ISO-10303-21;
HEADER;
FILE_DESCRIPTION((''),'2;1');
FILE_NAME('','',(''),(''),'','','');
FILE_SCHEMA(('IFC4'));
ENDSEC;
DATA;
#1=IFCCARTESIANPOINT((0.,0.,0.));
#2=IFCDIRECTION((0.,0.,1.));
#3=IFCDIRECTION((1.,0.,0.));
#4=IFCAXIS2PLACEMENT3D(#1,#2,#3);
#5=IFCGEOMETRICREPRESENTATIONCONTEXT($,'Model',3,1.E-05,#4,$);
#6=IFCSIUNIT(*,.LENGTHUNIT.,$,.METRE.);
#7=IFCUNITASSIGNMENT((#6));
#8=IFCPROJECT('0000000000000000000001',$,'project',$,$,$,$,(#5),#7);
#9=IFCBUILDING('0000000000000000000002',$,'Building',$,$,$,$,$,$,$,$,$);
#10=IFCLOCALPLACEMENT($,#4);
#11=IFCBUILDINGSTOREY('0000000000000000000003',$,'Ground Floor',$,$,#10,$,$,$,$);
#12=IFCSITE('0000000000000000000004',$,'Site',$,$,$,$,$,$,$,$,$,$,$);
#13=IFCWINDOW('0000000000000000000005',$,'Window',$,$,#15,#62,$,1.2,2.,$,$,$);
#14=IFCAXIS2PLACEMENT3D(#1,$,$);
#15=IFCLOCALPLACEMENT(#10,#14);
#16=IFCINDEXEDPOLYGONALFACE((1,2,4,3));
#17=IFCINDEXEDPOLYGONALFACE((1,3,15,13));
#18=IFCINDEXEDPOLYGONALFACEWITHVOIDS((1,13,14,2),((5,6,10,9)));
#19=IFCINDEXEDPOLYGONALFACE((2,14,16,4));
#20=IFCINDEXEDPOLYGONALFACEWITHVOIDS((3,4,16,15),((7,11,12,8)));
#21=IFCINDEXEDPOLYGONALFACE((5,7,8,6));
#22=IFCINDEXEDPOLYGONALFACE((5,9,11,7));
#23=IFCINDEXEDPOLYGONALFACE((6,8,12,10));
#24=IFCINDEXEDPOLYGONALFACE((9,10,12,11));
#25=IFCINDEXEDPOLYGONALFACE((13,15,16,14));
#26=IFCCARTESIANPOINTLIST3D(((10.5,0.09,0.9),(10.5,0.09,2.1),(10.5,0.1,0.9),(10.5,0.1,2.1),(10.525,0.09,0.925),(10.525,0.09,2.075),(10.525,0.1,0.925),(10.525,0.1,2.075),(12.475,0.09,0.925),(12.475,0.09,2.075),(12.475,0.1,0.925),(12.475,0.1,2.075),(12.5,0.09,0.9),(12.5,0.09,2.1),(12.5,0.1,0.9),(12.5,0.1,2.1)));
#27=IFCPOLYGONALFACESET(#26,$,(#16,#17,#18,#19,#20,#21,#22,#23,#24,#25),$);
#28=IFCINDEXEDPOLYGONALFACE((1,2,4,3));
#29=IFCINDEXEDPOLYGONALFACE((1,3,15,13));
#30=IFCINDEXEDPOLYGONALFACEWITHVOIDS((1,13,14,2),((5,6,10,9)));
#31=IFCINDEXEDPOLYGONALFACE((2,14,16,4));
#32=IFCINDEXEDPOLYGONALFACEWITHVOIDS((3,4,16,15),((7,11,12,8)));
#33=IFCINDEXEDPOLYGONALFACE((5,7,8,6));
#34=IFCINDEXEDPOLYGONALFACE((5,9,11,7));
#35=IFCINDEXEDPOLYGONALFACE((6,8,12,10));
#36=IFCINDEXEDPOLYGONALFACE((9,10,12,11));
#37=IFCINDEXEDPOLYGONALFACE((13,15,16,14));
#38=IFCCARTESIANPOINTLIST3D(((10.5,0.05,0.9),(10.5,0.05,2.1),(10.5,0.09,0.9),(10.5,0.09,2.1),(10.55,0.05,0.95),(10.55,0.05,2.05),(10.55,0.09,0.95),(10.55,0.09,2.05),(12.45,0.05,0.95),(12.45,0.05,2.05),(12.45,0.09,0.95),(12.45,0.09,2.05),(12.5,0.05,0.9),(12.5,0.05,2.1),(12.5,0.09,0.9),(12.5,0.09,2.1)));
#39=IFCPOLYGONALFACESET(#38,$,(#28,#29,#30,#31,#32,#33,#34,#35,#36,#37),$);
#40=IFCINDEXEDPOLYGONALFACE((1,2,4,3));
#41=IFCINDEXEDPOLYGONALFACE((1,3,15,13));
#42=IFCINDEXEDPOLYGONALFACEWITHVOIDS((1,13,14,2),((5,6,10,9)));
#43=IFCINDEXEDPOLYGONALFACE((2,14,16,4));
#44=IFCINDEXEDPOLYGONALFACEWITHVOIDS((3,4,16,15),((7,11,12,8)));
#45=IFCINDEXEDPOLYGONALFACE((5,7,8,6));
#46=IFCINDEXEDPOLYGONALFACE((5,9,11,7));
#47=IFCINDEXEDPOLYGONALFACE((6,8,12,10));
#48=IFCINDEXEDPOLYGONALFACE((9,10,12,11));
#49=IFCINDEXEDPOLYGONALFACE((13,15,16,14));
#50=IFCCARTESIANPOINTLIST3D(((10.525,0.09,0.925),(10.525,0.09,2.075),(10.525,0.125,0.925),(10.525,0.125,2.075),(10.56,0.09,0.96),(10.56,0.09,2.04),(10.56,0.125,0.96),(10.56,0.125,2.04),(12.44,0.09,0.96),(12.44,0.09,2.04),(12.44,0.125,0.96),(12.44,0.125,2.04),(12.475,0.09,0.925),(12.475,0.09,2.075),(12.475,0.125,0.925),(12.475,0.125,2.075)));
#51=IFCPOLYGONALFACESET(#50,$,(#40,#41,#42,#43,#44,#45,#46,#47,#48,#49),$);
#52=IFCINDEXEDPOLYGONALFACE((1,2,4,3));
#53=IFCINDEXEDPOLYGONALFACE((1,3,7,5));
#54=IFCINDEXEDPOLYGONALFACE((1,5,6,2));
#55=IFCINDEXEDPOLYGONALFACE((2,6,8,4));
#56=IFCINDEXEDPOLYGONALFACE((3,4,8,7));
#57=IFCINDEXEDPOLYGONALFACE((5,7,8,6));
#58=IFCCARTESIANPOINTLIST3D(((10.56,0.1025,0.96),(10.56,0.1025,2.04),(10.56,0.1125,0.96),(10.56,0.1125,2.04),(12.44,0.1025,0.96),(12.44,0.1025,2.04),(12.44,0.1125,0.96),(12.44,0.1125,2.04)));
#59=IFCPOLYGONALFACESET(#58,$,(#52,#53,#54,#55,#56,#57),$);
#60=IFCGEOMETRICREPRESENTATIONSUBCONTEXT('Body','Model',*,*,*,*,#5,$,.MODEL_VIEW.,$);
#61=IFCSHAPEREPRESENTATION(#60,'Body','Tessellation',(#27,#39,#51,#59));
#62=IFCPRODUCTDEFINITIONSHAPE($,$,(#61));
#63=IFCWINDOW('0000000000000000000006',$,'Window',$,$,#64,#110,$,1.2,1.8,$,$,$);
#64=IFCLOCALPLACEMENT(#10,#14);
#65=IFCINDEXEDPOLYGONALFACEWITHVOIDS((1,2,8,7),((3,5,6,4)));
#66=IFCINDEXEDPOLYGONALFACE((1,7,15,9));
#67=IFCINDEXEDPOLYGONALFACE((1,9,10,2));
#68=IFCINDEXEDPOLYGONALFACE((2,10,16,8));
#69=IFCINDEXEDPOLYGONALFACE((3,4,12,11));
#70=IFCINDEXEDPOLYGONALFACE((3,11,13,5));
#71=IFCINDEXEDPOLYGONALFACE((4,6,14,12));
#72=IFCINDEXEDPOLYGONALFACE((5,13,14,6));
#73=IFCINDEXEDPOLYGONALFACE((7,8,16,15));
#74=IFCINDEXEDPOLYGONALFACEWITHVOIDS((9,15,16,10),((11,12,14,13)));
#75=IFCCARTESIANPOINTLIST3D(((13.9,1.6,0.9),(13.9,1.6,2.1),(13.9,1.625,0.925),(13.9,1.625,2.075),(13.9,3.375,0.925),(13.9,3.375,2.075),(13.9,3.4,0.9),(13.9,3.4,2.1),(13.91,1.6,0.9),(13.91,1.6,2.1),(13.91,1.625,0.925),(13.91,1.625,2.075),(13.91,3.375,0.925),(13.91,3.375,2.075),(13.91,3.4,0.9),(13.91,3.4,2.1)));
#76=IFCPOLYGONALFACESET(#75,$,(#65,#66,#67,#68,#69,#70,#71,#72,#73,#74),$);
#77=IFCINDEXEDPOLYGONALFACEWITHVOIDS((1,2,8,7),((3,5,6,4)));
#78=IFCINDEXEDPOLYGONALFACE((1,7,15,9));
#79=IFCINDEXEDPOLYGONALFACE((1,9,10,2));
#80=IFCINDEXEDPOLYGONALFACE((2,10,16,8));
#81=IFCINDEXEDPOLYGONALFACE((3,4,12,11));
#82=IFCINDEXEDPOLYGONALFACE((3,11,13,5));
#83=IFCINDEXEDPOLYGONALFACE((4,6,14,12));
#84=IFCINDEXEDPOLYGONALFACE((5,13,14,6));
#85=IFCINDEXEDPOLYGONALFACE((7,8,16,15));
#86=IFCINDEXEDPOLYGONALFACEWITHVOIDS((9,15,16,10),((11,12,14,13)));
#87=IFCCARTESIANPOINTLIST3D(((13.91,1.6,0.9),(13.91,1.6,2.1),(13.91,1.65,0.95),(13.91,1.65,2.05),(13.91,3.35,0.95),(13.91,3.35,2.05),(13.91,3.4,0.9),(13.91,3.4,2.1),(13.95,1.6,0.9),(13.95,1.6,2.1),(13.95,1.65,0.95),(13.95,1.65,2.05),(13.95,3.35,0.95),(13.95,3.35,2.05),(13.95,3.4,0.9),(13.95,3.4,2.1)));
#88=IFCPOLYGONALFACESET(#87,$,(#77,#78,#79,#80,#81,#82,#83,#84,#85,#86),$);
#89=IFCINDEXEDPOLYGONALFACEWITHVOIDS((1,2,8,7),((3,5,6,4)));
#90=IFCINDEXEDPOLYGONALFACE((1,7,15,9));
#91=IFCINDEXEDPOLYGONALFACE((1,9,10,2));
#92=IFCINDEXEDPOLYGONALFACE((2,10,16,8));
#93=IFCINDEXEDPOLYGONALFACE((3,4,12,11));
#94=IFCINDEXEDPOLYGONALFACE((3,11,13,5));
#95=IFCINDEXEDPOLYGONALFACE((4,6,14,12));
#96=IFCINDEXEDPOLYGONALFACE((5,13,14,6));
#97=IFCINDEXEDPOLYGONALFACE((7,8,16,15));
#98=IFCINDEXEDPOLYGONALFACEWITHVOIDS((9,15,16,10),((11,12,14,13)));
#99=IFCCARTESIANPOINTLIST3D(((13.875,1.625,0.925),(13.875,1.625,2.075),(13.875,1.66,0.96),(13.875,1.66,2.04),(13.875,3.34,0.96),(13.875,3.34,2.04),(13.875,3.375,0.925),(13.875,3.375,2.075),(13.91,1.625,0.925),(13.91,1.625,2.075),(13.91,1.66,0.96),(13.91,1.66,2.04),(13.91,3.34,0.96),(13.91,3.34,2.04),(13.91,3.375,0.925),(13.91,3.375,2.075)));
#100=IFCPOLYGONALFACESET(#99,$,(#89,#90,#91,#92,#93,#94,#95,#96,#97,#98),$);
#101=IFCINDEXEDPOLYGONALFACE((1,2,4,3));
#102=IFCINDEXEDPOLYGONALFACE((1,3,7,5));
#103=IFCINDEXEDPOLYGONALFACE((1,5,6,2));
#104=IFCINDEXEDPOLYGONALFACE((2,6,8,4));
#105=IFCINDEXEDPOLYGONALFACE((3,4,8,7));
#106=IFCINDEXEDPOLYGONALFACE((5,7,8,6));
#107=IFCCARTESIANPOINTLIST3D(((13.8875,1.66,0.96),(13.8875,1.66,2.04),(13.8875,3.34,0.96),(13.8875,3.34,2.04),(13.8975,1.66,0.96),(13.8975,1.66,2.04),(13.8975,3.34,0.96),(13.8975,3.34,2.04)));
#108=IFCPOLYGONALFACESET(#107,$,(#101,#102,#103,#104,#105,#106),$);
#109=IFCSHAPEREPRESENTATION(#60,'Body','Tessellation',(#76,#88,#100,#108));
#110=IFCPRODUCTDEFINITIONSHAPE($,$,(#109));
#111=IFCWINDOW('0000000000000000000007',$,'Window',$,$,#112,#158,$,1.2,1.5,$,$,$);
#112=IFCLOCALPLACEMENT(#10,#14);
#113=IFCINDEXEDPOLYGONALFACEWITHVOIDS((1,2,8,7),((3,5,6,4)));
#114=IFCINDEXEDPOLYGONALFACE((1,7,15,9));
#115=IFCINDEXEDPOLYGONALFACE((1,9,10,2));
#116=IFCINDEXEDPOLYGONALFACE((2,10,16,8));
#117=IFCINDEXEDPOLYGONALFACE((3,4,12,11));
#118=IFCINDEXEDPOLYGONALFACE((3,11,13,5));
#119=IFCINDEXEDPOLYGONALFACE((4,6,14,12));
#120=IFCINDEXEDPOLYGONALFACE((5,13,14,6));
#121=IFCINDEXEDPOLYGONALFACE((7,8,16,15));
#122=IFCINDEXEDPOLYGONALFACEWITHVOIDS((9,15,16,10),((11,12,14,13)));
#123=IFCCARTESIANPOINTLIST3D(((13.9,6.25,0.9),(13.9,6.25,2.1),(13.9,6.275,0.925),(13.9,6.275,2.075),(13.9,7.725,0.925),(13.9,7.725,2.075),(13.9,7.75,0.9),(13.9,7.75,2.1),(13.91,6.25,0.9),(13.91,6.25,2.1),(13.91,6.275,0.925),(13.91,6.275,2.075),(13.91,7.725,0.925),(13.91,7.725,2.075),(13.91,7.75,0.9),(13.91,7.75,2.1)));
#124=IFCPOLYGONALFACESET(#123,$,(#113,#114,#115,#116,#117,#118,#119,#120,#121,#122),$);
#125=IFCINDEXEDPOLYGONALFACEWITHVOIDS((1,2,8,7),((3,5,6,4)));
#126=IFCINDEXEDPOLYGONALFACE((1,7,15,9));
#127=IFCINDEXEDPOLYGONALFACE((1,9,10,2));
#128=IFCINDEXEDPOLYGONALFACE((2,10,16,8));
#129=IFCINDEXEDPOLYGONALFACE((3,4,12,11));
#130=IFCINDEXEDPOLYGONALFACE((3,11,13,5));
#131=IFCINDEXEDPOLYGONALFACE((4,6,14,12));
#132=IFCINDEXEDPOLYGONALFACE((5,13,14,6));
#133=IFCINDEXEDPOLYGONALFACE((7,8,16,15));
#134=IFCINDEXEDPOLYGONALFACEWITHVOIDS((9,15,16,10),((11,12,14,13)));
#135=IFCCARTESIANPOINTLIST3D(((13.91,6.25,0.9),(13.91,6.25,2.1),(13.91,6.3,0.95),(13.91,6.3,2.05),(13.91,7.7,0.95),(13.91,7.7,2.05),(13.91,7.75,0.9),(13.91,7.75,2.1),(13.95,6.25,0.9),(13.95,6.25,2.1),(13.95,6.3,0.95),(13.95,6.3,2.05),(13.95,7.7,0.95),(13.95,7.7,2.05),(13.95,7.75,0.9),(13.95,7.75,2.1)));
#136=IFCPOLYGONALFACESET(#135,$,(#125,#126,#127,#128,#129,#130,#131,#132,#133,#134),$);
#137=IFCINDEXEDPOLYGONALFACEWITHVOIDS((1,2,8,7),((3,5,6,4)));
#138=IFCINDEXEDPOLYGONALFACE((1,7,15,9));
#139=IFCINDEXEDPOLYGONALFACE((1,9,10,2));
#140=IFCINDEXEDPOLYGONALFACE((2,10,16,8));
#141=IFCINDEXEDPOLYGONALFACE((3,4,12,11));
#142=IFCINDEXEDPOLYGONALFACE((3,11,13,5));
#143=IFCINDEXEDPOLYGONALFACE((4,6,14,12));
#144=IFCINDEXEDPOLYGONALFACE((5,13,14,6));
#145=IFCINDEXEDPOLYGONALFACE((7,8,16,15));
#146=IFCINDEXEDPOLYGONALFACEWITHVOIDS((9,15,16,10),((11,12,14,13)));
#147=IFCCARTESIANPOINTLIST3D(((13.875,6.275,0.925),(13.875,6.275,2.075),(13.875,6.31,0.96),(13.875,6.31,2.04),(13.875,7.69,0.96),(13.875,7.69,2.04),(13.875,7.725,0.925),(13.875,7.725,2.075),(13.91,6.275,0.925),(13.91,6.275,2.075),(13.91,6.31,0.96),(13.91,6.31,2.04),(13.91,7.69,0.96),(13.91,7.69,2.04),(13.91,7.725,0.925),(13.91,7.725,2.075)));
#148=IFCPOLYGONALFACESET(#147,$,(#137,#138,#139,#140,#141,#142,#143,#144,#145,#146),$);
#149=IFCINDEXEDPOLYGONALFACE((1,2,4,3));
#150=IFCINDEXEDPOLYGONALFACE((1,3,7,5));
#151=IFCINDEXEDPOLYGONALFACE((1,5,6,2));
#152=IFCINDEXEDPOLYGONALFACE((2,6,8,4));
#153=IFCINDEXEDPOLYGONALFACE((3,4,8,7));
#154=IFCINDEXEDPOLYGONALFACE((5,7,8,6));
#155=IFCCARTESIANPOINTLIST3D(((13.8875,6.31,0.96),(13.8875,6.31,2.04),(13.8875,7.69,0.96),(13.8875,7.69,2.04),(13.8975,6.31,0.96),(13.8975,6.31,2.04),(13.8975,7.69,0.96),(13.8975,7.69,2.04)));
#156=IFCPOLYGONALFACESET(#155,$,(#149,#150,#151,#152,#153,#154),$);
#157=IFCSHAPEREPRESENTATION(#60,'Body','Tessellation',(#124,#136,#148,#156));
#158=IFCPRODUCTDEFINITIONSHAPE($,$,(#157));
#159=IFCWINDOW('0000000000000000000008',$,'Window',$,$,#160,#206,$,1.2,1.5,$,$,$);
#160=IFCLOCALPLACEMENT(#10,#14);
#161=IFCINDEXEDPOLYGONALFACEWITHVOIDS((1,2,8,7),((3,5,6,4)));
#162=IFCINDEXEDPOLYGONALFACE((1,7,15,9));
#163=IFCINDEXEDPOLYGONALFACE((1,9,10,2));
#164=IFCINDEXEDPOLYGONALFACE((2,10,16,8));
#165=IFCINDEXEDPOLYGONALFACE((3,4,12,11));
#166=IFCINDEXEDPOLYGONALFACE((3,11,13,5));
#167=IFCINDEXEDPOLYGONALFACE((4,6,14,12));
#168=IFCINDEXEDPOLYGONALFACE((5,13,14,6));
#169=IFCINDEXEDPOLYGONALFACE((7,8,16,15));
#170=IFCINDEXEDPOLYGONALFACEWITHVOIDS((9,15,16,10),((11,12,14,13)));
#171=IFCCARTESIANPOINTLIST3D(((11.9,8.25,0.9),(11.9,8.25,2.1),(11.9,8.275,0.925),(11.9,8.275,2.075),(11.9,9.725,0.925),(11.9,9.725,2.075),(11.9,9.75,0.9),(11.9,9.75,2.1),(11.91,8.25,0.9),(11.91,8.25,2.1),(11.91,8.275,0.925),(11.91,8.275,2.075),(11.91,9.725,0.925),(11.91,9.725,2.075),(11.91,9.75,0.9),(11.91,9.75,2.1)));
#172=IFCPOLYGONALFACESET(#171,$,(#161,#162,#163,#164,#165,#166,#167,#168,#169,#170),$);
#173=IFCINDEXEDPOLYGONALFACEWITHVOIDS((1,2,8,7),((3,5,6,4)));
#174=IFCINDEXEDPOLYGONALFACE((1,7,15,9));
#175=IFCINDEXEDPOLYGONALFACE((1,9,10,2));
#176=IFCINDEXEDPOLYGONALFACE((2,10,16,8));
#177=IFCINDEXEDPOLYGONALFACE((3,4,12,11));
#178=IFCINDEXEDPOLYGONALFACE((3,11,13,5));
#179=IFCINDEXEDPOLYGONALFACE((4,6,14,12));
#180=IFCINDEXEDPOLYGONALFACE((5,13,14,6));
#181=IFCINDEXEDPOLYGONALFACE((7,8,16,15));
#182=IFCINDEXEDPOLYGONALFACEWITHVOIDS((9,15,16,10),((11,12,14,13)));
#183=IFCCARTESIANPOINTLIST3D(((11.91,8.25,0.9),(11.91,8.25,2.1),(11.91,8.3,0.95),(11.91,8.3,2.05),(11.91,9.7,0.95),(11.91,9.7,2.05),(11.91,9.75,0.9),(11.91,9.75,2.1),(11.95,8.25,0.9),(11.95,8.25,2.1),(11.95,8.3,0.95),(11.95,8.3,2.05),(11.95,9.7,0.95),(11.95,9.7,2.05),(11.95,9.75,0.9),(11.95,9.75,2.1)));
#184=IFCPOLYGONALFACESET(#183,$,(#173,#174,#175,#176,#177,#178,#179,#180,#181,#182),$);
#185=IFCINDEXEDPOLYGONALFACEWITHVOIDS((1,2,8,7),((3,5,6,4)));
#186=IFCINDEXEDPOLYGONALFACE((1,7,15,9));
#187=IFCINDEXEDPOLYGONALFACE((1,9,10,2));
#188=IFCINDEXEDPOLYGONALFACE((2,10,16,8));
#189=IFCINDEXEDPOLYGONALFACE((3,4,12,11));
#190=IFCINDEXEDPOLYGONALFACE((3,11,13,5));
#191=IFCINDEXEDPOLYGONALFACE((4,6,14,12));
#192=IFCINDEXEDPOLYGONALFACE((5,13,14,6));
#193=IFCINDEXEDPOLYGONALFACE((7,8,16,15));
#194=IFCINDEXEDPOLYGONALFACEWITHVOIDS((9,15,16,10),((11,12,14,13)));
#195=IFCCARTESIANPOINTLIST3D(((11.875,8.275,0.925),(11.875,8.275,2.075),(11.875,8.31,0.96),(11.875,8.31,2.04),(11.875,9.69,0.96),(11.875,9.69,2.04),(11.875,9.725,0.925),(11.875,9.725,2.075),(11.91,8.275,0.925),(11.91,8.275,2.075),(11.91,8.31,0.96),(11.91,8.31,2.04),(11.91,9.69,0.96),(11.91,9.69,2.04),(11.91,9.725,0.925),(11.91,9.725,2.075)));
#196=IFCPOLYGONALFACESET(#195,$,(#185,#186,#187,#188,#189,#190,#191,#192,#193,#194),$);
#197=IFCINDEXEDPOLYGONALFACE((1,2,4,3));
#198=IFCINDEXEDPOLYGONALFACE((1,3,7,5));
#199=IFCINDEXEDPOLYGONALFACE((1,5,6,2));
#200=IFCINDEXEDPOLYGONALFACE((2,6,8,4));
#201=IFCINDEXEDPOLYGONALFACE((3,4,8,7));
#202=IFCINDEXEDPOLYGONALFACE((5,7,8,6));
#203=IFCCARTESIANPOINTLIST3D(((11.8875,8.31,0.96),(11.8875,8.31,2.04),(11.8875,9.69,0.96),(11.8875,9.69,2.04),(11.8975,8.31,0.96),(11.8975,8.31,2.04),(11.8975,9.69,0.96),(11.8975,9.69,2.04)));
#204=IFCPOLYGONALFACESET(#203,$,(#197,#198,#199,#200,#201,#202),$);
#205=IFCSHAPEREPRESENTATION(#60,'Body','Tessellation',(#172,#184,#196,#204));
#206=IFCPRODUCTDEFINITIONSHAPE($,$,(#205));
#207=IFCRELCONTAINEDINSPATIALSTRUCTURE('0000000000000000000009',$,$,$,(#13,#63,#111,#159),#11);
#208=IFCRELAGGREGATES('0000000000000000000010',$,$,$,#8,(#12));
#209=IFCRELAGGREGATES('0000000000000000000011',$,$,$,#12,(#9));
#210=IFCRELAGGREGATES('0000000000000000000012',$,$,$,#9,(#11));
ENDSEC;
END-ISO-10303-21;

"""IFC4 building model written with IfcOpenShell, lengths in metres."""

from ifc_helpers import new_model, si_unit, frame, origin_with_axes, place, context, subcontext, project, spatial, line, indexed_curve, outline, extrude, element, save


model = new_model("IFC4")

# Units and contexts
model_context = context("Model", 3, precision=1e-05, world=origin_with_axes())
body_context = subcontext(model_context, "Body", "Model", "MODEL_VIEW")
ifc_project = project(units=[si_unit("LENGTHUNIT", "METRE")], contexts=[model_context])

# Site, building, storey
site = spatial("IfcSite", under=ifc_project, Name="Site")
building = spatial("IfcBuilding", under=site, Name="Building")
storey_placement = place(None, origin_with_axes())
storey = spatial("IfcBuildingStorey", under=building, at=storey_placement, Name="Ground Floor")

# Windows
window_1_placement = place(storey_placement, frame((10.5, 0.0, 0.9), z_axis=(0.0, 0.0, 1.0), x_axis=(1.0, 0.0, 0.0)))
element("IfcWindow", 1, at=window_1_placement, inside=storey, Name="Window", OverallHeight=1.2, OverallWidth=2.0, context=body_context, shape_type="SweptSolid", body=[
    extrude(outline(indexed_curve([(0.0, 0.0), (2.0, 0.0), (2.0, 1.2), (0.0, 1.2)], segments=[line(1, 2, 3, 4, 1)]), holes=[indexed_curve([(0.025, 0.025), (1.975, 0.025), (1.975, 1.175), (0.025, 1.175)], segments=[line(1, 2, 3, 4, 1)])]), frame((0.0, 0.09, 0.0), z_axis=(0.0, -1.0, 0.0), x_axis=(1.0, 0.0, 0.0)), (0.0, 0.0, -1.0), 0.01),
    extrude(outline(indexed_curve([(0.0, 0.0), (2.0, 0.0), (2.0, 1.2), (0.0, 1.2)], segments=[line(1, 2, 3, 4, 1)]), holes=[indexed_curve([(0.05, 0.05), (1.95, 0.05), (1.95, 1.15), (0.05, 1.15)], segments=[line(1, 2, 3, 4, 1)])]), frame((0.0, 0.05, 0.0), z_axis=(0.0, -1.0, 0.0), x_axis=(1.0, 0.0, 0.0)), (0.0, 0.0, -1.0), 0.04),
    extrude(outline(indexed_curve([(0.0, 0.0), (1.95, 0.0), (1.95, 1.15), (0.0, 1.15)], segments=[line(1, 2, 3, 4, 1)]), holes=[indexed_curve([(0.035, 0.035), (1.915, 0.035), (1.915, 1.115), (0.035, 1.115)], segments=[line(1, 2, 3, 4, 1)])]), frame((0.025, 0.09, 0.025), z_axis=(0.0, -1.0, 0.0), x_axis=(1.0, 0.0, 0.0)), (0.0, 0.0, -1.0), 0.035),
    extrude(outline(indexed_curve([(0.035, 0.035), (1.915, 0.035), (1.915, 1.115), (0.035, 1.115)], segments=[line(1, 2, 3, 4, 1)])), frame((0.025, 0.1025, 0.025), z_axis=(0.0, -1.0, 0.0), x_axis=(1.0, 0.0, 0.0)), (0.0, 0.0, -1.0), 0.01),
])
window_2_placement = place(storey_placement, frame((14.0, 1.6, 0.9), z_axis=(0.0, 0.0, 1.0), x_axis=(0.0, 1.0, 0.0)))
element("IfcWindow", 2, at=window_2_placement, inside=storey, Name="Window", OverallHeight=1.2, OverallWidth=1.8, context=body_context, shape_type="SweptSolid", body=[
    extrude(outline(indexed_curve([(0.0, 0.0), (1.8, 0.0), (1.8, 1.2), (0.0, 1.2)], segments=[line(1, 2, 3, 4, 1)]), holes=[indexed_curve([(0.025, 0.025), (1.775, 0.025), (1.775, 1.175), (0.025, 1.175)], segments=[line(1, 2, 3, 4, 1)])]), frame((0.0, 0.09, 0.0), z_axis=(0.0, -1.0, 0.0), x_axis=(1.0, 0.0, 0.0)), (0.0, 0.0, -1.0), 0.01),
    extrude(outline(indexed_curve([(0.0, 0.0), (1.8, 0.0), (1.8, 1.2), (0.0, 1.2)], segments=[line(1, 2, 3, 4, 1)]), holes=[indexed_curve([(0.05, 0.05), (1.75, 0.05), (1.75, 1.15), (0.05, 1.15)], segments=[line(1, 2, 3, 4, 1)])]), frame((0.0, 0.05, 0.0), z_axis=(0.0, -1.0, 0.0), x_axis=(1.0, 0.0, 0.0)), (0.0, 0.0, -1.0), 0.04),
    extrude(outline(indexed_curve([(0.0, 0.0), (1.75, 0.0), (1.75, 1.15), (0.0, 1.15)], segments=[line(1, 2, 3, 4, 1)]), holes=[indexed_curve([(0.035, 0.035), (1.715, 0.035), (1.715, 1.115), (0.035, 1.115)], segments=[line(1, 2, 3, 4, 1)])]), frame((0.025, 0.09, 0.025), z_axis=(0.0, -1.0, 0.0), x_axis=(1.0, 0.0, 0.0)), (0.0, 0.0, -1.0), 0.035),
    extrude(outline(indexed_curve([(0.035, 0.035), (1.715, 0.035), (1.715, 1.115), (0.035, 1.115)], segments=[line(1, 2, 3, 4, 1)])), frame((0.025, 0.1025, 0.025), z_axis=(0.0, -1.0, 0.0), x_axis=(1.0, 0.0, 0.0)), (0.0, 0.0, -1.0), 0.01),
])
for number, where, z_axis, x_axis, name in (
    (3, (14.0, 6.25, 0.9), (0.0, 0.0, 1.0), (0.0, 1.0, 0.0), "Window"),
    (4, (12.0, 8.25, 0.9), (0.0, 0.0, 1.0), (0.0, 1.0, 0.0), "Window"),
):
    element("IfcWindow", number, at=place(storey_placement, frame(where, z_axis=z_axis, x_axis=x_axis)), inside=storey, Name=name, OverallHeight=1.2, OverallWidth=1.5, context=body_context, shape_type="SweptSolid", body=[
        extrude(outline(indexed_curve([(0.0, 0.0), (1.5, 0.0), (1.5, 1.2), (0.0, 1.2)], segments=[line(1, 2, 3, 4, 1)]), holes=[indexed_curve([(0.025, 0.025), (1.475, 0.025), (1.475, 1.175), (0.025, 1.175)], segments=[line(1, 2, 3, 4, 1)])]), frame((0.0, 0.09, 0.0), z_axis=(0.0, -1.0, 0.0), x_axis=(1.0, 0.0, 0.0)), (0.0, 0.0, -1.0), 0.01),
        extrude(outline(indexed_curve([(0.0, 0.0), (1.5, 0.0), (1.5, 1.2), (0.0, 1.2)], segments=[line(1, 2, 3, 4, 1)]), holes=[indexed_curve([(0.05, 0.05), (1.45, 0.05), (1.45, 1.15), (0.05, 1.15)], segments=[line(1, 2, 3, 4, 1)])]), frame((0.0, 0.05, 0.0), z_axis=(0.0, -1.0, 0.0), x_axis=(1.0, 0.0, 0.0)), (0.0, 0.0, -1.0), 0.04),
        extrude(outline(indexed_curve([(0.0, 0.0), (1.45, 0.0), (1.45, 1.15), (0.0, 1.15)], segments=[line(1, 2, 3, 4, 1)]), holes=[indexed_curve([(0.035, 0.035), (1.415, 0.035), (1.415, 1.115), (0.035, 1.115)], segments=[line(1, 2, 3, 4, 1)])]), frame((0.025, 0.09, 0.025), z_axis=(0.0, -1.0, 0.0), x_axis=(1.0, 0.0, 0.0)), (0.0, 0.0, -1.0), 0.035),
        extrude(outline(indexed_curve([(0.035, 0.035), (1.415, 0.035), (1.415, 1.115), (0.035, 1.115)], segments=[line(1, 2, 3, 4, 1)])), frame((0.025, 0.1025, 0.025), z_axis=(0.0, -1.0, 0.0), x_axis=(1.0, 0.0, 0.0)), (0.0, 0.0, -1.0), 0.01),
    ])

save(model, "model.ifc")
